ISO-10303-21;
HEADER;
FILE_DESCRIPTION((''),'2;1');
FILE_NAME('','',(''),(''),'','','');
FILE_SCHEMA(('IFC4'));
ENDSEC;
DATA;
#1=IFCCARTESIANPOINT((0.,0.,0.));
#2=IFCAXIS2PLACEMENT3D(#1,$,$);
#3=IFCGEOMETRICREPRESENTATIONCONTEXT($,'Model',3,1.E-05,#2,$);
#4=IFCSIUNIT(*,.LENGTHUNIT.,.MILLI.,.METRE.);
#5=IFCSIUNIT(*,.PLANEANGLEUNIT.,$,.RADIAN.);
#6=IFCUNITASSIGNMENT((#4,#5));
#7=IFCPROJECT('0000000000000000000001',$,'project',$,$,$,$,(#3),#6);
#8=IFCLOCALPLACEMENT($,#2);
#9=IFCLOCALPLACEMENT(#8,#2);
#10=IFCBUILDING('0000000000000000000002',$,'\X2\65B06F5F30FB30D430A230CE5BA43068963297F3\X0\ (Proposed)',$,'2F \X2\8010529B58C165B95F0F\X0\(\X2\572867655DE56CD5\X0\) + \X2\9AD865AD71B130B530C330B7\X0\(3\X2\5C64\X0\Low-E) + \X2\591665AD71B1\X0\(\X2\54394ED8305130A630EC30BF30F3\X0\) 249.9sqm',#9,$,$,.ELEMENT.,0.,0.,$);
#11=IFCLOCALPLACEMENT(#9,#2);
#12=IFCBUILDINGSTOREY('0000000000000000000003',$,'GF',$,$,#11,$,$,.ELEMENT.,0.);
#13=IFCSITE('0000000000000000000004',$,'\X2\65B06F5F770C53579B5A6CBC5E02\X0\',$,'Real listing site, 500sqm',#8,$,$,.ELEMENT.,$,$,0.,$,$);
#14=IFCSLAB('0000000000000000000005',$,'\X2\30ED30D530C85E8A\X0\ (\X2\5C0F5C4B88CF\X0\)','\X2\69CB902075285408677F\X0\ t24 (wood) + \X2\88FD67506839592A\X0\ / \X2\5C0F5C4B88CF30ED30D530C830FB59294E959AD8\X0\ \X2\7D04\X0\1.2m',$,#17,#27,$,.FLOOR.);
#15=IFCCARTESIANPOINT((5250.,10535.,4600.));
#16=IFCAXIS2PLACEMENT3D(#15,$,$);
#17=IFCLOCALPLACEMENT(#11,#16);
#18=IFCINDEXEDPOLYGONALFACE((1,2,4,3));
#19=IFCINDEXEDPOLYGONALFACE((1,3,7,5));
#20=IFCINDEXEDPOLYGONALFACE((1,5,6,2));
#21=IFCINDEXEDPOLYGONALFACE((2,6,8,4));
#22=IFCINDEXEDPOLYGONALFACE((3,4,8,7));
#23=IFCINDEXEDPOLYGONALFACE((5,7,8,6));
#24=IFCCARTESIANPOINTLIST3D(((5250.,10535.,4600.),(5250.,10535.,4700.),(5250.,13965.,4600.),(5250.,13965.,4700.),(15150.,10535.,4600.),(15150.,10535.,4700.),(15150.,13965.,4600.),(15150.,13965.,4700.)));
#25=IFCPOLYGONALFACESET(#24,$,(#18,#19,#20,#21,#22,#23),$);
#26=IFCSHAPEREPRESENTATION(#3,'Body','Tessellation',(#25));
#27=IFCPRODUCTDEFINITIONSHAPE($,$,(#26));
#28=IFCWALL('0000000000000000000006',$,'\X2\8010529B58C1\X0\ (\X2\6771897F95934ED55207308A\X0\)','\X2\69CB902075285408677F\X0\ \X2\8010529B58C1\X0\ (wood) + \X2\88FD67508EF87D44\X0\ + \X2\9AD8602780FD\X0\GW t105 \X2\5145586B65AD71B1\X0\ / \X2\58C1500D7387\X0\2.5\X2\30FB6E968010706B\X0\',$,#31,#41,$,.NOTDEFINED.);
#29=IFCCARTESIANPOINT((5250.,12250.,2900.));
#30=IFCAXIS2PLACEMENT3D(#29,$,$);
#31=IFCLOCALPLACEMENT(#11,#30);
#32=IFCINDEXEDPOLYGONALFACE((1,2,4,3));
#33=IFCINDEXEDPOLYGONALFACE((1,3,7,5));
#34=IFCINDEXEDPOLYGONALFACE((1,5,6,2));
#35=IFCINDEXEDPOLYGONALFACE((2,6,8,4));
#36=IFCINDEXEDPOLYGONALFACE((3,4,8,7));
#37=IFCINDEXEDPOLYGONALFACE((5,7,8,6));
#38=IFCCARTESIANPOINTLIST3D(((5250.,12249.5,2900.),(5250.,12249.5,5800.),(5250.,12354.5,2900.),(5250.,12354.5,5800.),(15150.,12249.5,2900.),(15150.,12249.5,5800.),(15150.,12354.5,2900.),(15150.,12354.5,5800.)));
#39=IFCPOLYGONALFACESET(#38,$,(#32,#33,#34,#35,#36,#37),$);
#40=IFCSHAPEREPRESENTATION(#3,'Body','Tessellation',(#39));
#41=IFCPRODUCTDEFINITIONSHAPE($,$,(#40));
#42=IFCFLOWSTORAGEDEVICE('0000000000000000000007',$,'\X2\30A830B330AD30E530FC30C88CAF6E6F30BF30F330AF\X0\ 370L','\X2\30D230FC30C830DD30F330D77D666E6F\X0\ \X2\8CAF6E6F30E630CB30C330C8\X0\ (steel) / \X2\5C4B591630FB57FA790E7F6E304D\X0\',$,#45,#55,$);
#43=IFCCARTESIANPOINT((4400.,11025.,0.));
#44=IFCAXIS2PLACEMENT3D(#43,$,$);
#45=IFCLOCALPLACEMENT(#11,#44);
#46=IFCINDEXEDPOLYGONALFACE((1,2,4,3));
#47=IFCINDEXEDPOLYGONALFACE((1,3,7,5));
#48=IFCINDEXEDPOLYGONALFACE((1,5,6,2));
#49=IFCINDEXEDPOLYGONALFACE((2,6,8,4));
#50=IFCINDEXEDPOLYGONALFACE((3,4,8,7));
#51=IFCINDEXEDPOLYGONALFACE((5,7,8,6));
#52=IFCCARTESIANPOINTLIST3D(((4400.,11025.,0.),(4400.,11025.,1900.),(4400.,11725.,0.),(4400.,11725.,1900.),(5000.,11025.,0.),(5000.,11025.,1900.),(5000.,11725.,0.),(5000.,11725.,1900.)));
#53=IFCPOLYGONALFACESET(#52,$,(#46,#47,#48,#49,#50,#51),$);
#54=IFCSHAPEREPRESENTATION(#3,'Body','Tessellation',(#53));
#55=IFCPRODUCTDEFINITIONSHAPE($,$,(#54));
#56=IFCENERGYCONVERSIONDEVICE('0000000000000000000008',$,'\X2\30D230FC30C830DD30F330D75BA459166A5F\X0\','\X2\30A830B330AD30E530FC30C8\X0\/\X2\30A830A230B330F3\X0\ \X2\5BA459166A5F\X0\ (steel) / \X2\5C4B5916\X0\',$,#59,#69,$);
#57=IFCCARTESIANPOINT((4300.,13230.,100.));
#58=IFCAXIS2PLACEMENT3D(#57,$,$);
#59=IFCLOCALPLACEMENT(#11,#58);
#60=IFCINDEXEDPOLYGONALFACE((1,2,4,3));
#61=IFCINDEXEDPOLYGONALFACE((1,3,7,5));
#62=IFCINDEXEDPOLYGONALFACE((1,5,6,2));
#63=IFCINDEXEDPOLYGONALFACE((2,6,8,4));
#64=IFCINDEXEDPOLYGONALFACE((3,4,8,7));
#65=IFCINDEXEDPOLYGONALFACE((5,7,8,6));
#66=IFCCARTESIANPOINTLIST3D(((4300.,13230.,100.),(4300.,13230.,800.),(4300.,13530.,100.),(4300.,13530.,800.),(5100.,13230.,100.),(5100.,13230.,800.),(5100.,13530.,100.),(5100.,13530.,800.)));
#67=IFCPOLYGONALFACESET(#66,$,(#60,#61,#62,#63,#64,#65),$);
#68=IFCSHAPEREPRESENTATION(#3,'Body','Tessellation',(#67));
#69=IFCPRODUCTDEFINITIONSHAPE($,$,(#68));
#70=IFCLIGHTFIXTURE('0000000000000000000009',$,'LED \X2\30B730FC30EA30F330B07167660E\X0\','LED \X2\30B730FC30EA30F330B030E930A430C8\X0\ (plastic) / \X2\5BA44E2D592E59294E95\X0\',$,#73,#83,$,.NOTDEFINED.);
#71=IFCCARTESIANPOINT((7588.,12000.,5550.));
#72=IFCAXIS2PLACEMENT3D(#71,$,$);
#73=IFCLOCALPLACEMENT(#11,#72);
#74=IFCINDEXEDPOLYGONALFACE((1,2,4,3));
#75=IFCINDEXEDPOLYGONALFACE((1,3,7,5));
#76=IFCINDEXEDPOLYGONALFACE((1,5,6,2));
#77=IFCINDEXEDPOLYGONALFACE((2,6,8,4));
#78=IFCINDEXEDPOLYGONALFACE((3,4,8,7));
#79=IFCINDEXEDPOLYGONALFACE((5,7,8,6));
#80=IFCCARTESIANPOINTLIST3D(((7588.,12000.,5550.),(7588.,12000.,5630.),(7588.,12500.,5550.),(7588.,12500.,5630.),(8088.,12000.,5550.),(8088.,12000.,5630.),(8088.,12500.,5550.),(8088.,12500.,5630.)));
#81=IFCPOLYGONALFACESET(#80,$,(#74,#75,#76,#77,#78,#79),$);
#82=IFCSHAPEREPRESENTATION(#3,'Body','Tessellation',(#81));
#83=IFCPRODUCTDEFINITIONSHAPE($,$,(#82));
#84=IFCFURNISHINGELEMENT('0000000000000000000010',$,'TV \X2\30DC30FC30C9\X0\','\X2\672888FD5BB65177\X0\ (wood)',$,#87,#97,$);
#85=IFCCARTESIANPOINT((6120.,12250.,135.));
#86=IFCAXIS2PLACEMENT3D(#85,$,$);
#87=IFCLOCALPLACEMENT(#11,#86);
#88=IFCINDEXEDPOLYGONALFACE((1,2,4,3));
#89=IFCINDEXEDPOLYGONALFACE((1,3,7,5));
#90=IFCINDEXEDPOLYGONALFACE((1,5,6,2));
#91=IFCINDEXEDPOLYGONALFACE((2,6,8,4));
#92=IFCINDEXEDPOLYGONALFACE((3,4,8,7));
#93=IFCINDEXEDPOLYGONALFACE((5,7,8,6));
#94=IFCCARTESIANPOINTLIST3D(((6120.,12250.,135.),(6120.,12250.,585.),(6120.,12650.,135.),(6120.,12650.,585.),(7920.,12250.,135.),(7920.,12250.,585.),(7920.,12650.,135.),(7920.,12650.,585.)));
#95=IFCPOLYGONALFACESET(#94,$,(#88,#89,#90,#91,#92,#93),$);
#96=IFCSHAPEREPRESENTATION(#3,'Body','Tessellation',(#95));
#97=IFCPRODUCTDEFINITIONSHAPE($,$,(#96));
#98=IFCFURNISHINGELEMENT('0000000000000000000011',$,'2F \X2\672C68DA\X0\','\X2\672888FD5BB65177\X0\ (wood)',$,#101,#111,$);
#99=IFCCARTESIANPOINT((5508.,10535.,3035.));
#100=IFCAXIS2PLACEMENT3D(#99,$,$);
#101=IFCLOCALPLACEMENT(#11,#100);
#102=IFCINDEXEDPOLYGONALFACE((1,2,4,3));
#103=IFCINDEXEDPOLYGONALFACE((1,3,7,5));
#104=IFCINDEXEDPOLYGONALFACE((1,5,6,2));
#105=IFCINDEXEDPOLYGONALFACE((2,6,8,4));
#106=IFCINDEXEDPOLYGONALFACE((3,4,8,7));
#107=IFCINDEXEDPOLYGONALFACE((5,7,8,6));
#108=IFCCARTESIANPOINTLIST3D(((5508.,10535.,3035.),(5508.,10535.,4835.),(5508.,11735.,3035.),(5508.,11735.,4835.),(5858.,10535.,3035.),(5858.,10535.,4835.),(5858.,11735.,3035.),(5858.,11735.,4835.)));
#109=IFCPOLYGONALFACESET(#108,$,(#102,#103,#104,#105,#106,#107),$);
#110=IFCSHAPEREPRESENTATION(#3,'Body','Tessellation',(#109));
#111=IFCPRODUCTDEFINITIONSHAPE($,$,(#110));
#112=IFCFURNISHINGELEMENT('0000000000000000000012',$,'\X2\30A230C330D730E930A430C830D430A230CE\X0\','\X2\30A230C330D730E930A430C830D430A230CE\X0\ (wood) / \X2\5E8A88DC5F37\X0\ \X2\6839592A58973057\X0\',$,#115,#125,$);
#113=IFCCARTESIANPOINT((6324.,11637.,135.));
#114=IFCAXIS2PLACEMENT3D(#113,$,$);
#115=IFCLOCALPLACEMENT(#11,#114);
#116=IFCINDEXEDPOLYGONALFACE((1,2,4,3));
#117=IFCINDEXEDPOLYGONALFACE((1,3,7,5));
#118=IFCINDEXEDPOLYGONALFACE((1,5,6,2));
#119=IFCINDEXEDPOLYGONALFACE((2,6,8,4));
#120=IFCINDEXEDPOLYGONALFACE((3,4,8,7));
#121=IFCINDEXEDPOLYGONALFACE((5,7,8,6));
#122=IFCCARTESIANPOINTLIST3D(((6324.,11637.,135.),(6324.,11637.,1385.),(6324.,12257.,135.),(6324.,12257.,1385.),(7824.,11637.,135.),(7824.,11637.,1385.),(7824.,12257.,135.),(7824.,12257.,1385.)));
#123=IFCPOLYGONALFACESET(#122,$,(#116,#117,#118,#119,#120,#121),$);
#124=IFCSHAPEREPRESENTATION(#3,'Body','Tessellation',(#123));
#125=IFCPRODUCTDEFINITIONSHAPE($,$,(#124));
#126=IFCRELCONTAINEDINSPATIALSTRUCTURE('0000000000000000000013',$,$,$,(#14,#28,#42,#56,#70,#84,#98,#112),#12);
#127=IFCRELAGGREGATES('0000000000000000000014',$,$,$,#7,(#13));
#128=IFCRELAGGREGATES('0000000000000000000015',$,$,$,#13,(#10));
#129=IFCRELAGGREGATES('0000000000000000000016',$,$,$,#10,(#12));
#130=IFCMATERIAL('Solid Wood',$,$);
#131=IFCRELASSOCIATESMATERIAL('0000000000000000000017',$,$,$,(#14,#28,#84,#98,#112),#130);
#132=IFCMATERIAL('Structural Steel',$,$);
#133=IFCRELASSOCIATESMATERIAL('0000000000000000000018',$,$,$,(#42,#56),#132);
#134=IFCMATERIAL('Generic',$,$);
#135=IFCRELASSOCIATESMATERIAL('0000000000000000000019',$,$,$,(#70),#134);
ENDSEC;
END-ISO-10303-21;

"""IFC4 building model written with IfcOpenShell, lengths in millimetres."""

from ifc_helpers import new_model, si_unit, frame, frame_2d, origin, place, context, project, spatial, rectangle, extrude, material, element, save


model = new_model("IFC4")

# Units and contexts
model_context = context("Model", 3, precision=1e-05, world=origin())
ifc_project = project(units=[si_unit("LENGTHUNIT", "METRE", prefix="MILLI"), si_unit("PLANEANGLEUNIT", "RADIAN")], contexts=[model_context])

# Site, building, storey
site_placement = place(None, origin())
site = spatial("IfcSite", under=ifc_project, at=site_placement, Name="新潟県南魚沼市", ObjectType="Real listing site, 500sqm", CompositionType="ELEMENT", RefElevation=0.0)
building_placement = place(site_placement, origin())
building = spatial("IfcBuilding", under=site, at=building_placement, Name="新潟・ピアノ室と防音 (Proposed)", ObjectType="2F 耐力壁方式(在来工法) + 高断熱サッシ(3層Low-E) + 外断熱(吹付けウレタン) 249.9sqm", CompositionType="ELEMENT", ElevationOfRefHeight=0.0, ElevationOfTerrain=0.0)
storey_placement = place(building_placement, origin())
storey = spatial("IfcBuildingStorey", under=building, at=storey_placement, Name="GF", CompositionType="ELEMENT", Elevation=0.0)

# Shared definitions
ifc_material_1 = material(Name="Solid Wood")

# Slab
slab_placement = place(storey_placement, frame((5250.0, 10535.0, 4600.0)))
element("IfcSlab", 1, at=slab_placement, inside=storey, material=ifc_material_1, Name="ロフト床 (小屋裏)", Description="構造用合板 t24 (wood) + 製材根太 / 小屋裏ロフト・天井高 約1.2m", PredefinedType="FLOOR", context=model_context, shape_type="SweptSolid", body=[
    extrude(rectangle(XDim=9900.0, YDim=3430.0, at=frame_2d((4950.0, 1715.0))), frame((5250.0, 10535.0, 4600.0)), (0.0, 0.0, 1.0), 100.0),
])

# Wall
wall_1_placement = place(storey_placement, frame((5250.0, 12250.0, 2900.0)))
element("IfcWall", 2, at=wall_1_placement, inside=storey, material=ifc_material_1, Name="耐力壁 (東西間仕切り)", Description="構造用合板 耐力壁 (wood) + 製材軸組 + 高性能GW t105 充填断熱 / 壁倍率2.5・準耐火", PredefinedType="NOTDEFINED", context=model_context, shape_type="SweptSolid", body=[
    extrude(rectangle(XDim=9900.0, YDim=105.0, at=frame_2d((4950.0, 52.0))), frame((5250.0, 12250.0, 2900.0)), (0.0, 0.0, 1.0), 2900.0),
])

# Flow storage device
ifc_material_2 = material(Name="Structural Steel")
flow_storage_device_placement = place(storey_placement, frame((4400.0, 11025.0, 0.0)))
element("IfcFlowStorageDevice", 3, at=flow_storage_device_placement, inside=storey, material=ifc_material_2, Name="エコキュート貯湯タンク 370L", Description="ヒートポンプ給湯 貯湯ユニット (steel) / 屋外・基礎置き", context=model_context, shape_type="SweptSolid", body=[
    extrude(rectangle(XDim=600.0, YDim=700.0, at=frame_2d((300.0, 350.0))), frame((4400.0, 11025.0, 0.0)), (0.0, 0.0, 1.0), 1900.0),
])

# Energy conversion device
energy_conversion_device_placement = place(storey_placement, frame((4300.0, 13230.0, 100.0)))
element("IfcEnergyConversionDevice", 4, at=energy_conversion_device_placement, inside=storey, material=ifc_material_2, Name="ヒートポンプ室外機", Description="エコキュート/エアコン 室外機 (steel) / 屋外", context=model_context, shape_type="SweptSolid", body=[
    extrude(rectangle(XDim=800.0, YDim=300.0, at=frame_2d((400.0, 150.0))), frame((4300.0, 13230.0, 100.0)), (0.0, 0.0, 1.0), 700.0),
])

# Light fixture
ifc_material_3 = material(Name="Generic")
light_fixture_placement = place(storey_placement, frame((7588.0, 12000.0, 5550.0)))
element("IfcLightFixture", 5, at=light_fixture_placement, inside=storey, material=ifc_material_3, Name="LED シーリング照明", Description="LED シーリングライト (plastic) / 室中央天井", PredefinedType="NOTDEFINED", context=model_context, shape_type="SweptSolid", body=[
    extrude(rectangle(XDim=500.0, YDim=500.0, at=frame_2d((250.0, 250.0))), frame((7588.0, 12000.0, 5550.0)), (0.0, 0.0, 1.0), 80.0),
])

# Furnishing elements
furnishing_1_placement = place(storey_placement, frame((6120.0, 12250.0, 135.0)))
element("IfcFurnishingElement", 6, at=furnishing_1_placement, inside=storey, material=ifc_material_1, Name="TV ボード", Description="木製家具 (wood)", context=model_context, shape_type="SweptSolid", body=[
    extrude(rectangle(XDim=1800.0, YDim=400.0, at=frame_2d((900.0, 200.0))), frame((6120.0, 12250.0, 135.0)), (0.0, 0.0, 1.0), 450.0),
])
furnishing_2_placement = place(storey_placement, frame((5508.0, 10535.0, 3035.0)))
element("IfcFurnishingElement", 7, at=furnishing_2_placement, inside=storey, material=ifc_material_1, Name="2F 本棚", Description="木製家具 (wood)", context=model_context, shape_type="SweptSolid", body=[
    extrude(rectangle(XDim=350.0, YDim=1200.0, at=frame_2d((175.0, 600.0))), frame((5508.0, 10535.0, 3035.0)), (0.0, 0.0, 1.0), 1800.0),
])
furnishing_3_placement = place(storey_placement, frame((6324.0, 11637.0, 135.0)))
element("IfcFurnishingElement", 8, at=furnishing_3_placement, inside=storey, material=ifc_material_1, Name="アップライトピアノ", Description="アップライトピアノ (wood) / 床補強 根太増し", context=model_context, shape_type="SweptSolid", body=[
    extrude(rectangle(XDim=1500.0, YDim=620.0, at=frame_2d((750.0, 310.0))), frame((6324.0, 11637.0, 135.0)), (0.0, 0.0, 1.0), 1250.0),
])

save(model, "model.ifc")
